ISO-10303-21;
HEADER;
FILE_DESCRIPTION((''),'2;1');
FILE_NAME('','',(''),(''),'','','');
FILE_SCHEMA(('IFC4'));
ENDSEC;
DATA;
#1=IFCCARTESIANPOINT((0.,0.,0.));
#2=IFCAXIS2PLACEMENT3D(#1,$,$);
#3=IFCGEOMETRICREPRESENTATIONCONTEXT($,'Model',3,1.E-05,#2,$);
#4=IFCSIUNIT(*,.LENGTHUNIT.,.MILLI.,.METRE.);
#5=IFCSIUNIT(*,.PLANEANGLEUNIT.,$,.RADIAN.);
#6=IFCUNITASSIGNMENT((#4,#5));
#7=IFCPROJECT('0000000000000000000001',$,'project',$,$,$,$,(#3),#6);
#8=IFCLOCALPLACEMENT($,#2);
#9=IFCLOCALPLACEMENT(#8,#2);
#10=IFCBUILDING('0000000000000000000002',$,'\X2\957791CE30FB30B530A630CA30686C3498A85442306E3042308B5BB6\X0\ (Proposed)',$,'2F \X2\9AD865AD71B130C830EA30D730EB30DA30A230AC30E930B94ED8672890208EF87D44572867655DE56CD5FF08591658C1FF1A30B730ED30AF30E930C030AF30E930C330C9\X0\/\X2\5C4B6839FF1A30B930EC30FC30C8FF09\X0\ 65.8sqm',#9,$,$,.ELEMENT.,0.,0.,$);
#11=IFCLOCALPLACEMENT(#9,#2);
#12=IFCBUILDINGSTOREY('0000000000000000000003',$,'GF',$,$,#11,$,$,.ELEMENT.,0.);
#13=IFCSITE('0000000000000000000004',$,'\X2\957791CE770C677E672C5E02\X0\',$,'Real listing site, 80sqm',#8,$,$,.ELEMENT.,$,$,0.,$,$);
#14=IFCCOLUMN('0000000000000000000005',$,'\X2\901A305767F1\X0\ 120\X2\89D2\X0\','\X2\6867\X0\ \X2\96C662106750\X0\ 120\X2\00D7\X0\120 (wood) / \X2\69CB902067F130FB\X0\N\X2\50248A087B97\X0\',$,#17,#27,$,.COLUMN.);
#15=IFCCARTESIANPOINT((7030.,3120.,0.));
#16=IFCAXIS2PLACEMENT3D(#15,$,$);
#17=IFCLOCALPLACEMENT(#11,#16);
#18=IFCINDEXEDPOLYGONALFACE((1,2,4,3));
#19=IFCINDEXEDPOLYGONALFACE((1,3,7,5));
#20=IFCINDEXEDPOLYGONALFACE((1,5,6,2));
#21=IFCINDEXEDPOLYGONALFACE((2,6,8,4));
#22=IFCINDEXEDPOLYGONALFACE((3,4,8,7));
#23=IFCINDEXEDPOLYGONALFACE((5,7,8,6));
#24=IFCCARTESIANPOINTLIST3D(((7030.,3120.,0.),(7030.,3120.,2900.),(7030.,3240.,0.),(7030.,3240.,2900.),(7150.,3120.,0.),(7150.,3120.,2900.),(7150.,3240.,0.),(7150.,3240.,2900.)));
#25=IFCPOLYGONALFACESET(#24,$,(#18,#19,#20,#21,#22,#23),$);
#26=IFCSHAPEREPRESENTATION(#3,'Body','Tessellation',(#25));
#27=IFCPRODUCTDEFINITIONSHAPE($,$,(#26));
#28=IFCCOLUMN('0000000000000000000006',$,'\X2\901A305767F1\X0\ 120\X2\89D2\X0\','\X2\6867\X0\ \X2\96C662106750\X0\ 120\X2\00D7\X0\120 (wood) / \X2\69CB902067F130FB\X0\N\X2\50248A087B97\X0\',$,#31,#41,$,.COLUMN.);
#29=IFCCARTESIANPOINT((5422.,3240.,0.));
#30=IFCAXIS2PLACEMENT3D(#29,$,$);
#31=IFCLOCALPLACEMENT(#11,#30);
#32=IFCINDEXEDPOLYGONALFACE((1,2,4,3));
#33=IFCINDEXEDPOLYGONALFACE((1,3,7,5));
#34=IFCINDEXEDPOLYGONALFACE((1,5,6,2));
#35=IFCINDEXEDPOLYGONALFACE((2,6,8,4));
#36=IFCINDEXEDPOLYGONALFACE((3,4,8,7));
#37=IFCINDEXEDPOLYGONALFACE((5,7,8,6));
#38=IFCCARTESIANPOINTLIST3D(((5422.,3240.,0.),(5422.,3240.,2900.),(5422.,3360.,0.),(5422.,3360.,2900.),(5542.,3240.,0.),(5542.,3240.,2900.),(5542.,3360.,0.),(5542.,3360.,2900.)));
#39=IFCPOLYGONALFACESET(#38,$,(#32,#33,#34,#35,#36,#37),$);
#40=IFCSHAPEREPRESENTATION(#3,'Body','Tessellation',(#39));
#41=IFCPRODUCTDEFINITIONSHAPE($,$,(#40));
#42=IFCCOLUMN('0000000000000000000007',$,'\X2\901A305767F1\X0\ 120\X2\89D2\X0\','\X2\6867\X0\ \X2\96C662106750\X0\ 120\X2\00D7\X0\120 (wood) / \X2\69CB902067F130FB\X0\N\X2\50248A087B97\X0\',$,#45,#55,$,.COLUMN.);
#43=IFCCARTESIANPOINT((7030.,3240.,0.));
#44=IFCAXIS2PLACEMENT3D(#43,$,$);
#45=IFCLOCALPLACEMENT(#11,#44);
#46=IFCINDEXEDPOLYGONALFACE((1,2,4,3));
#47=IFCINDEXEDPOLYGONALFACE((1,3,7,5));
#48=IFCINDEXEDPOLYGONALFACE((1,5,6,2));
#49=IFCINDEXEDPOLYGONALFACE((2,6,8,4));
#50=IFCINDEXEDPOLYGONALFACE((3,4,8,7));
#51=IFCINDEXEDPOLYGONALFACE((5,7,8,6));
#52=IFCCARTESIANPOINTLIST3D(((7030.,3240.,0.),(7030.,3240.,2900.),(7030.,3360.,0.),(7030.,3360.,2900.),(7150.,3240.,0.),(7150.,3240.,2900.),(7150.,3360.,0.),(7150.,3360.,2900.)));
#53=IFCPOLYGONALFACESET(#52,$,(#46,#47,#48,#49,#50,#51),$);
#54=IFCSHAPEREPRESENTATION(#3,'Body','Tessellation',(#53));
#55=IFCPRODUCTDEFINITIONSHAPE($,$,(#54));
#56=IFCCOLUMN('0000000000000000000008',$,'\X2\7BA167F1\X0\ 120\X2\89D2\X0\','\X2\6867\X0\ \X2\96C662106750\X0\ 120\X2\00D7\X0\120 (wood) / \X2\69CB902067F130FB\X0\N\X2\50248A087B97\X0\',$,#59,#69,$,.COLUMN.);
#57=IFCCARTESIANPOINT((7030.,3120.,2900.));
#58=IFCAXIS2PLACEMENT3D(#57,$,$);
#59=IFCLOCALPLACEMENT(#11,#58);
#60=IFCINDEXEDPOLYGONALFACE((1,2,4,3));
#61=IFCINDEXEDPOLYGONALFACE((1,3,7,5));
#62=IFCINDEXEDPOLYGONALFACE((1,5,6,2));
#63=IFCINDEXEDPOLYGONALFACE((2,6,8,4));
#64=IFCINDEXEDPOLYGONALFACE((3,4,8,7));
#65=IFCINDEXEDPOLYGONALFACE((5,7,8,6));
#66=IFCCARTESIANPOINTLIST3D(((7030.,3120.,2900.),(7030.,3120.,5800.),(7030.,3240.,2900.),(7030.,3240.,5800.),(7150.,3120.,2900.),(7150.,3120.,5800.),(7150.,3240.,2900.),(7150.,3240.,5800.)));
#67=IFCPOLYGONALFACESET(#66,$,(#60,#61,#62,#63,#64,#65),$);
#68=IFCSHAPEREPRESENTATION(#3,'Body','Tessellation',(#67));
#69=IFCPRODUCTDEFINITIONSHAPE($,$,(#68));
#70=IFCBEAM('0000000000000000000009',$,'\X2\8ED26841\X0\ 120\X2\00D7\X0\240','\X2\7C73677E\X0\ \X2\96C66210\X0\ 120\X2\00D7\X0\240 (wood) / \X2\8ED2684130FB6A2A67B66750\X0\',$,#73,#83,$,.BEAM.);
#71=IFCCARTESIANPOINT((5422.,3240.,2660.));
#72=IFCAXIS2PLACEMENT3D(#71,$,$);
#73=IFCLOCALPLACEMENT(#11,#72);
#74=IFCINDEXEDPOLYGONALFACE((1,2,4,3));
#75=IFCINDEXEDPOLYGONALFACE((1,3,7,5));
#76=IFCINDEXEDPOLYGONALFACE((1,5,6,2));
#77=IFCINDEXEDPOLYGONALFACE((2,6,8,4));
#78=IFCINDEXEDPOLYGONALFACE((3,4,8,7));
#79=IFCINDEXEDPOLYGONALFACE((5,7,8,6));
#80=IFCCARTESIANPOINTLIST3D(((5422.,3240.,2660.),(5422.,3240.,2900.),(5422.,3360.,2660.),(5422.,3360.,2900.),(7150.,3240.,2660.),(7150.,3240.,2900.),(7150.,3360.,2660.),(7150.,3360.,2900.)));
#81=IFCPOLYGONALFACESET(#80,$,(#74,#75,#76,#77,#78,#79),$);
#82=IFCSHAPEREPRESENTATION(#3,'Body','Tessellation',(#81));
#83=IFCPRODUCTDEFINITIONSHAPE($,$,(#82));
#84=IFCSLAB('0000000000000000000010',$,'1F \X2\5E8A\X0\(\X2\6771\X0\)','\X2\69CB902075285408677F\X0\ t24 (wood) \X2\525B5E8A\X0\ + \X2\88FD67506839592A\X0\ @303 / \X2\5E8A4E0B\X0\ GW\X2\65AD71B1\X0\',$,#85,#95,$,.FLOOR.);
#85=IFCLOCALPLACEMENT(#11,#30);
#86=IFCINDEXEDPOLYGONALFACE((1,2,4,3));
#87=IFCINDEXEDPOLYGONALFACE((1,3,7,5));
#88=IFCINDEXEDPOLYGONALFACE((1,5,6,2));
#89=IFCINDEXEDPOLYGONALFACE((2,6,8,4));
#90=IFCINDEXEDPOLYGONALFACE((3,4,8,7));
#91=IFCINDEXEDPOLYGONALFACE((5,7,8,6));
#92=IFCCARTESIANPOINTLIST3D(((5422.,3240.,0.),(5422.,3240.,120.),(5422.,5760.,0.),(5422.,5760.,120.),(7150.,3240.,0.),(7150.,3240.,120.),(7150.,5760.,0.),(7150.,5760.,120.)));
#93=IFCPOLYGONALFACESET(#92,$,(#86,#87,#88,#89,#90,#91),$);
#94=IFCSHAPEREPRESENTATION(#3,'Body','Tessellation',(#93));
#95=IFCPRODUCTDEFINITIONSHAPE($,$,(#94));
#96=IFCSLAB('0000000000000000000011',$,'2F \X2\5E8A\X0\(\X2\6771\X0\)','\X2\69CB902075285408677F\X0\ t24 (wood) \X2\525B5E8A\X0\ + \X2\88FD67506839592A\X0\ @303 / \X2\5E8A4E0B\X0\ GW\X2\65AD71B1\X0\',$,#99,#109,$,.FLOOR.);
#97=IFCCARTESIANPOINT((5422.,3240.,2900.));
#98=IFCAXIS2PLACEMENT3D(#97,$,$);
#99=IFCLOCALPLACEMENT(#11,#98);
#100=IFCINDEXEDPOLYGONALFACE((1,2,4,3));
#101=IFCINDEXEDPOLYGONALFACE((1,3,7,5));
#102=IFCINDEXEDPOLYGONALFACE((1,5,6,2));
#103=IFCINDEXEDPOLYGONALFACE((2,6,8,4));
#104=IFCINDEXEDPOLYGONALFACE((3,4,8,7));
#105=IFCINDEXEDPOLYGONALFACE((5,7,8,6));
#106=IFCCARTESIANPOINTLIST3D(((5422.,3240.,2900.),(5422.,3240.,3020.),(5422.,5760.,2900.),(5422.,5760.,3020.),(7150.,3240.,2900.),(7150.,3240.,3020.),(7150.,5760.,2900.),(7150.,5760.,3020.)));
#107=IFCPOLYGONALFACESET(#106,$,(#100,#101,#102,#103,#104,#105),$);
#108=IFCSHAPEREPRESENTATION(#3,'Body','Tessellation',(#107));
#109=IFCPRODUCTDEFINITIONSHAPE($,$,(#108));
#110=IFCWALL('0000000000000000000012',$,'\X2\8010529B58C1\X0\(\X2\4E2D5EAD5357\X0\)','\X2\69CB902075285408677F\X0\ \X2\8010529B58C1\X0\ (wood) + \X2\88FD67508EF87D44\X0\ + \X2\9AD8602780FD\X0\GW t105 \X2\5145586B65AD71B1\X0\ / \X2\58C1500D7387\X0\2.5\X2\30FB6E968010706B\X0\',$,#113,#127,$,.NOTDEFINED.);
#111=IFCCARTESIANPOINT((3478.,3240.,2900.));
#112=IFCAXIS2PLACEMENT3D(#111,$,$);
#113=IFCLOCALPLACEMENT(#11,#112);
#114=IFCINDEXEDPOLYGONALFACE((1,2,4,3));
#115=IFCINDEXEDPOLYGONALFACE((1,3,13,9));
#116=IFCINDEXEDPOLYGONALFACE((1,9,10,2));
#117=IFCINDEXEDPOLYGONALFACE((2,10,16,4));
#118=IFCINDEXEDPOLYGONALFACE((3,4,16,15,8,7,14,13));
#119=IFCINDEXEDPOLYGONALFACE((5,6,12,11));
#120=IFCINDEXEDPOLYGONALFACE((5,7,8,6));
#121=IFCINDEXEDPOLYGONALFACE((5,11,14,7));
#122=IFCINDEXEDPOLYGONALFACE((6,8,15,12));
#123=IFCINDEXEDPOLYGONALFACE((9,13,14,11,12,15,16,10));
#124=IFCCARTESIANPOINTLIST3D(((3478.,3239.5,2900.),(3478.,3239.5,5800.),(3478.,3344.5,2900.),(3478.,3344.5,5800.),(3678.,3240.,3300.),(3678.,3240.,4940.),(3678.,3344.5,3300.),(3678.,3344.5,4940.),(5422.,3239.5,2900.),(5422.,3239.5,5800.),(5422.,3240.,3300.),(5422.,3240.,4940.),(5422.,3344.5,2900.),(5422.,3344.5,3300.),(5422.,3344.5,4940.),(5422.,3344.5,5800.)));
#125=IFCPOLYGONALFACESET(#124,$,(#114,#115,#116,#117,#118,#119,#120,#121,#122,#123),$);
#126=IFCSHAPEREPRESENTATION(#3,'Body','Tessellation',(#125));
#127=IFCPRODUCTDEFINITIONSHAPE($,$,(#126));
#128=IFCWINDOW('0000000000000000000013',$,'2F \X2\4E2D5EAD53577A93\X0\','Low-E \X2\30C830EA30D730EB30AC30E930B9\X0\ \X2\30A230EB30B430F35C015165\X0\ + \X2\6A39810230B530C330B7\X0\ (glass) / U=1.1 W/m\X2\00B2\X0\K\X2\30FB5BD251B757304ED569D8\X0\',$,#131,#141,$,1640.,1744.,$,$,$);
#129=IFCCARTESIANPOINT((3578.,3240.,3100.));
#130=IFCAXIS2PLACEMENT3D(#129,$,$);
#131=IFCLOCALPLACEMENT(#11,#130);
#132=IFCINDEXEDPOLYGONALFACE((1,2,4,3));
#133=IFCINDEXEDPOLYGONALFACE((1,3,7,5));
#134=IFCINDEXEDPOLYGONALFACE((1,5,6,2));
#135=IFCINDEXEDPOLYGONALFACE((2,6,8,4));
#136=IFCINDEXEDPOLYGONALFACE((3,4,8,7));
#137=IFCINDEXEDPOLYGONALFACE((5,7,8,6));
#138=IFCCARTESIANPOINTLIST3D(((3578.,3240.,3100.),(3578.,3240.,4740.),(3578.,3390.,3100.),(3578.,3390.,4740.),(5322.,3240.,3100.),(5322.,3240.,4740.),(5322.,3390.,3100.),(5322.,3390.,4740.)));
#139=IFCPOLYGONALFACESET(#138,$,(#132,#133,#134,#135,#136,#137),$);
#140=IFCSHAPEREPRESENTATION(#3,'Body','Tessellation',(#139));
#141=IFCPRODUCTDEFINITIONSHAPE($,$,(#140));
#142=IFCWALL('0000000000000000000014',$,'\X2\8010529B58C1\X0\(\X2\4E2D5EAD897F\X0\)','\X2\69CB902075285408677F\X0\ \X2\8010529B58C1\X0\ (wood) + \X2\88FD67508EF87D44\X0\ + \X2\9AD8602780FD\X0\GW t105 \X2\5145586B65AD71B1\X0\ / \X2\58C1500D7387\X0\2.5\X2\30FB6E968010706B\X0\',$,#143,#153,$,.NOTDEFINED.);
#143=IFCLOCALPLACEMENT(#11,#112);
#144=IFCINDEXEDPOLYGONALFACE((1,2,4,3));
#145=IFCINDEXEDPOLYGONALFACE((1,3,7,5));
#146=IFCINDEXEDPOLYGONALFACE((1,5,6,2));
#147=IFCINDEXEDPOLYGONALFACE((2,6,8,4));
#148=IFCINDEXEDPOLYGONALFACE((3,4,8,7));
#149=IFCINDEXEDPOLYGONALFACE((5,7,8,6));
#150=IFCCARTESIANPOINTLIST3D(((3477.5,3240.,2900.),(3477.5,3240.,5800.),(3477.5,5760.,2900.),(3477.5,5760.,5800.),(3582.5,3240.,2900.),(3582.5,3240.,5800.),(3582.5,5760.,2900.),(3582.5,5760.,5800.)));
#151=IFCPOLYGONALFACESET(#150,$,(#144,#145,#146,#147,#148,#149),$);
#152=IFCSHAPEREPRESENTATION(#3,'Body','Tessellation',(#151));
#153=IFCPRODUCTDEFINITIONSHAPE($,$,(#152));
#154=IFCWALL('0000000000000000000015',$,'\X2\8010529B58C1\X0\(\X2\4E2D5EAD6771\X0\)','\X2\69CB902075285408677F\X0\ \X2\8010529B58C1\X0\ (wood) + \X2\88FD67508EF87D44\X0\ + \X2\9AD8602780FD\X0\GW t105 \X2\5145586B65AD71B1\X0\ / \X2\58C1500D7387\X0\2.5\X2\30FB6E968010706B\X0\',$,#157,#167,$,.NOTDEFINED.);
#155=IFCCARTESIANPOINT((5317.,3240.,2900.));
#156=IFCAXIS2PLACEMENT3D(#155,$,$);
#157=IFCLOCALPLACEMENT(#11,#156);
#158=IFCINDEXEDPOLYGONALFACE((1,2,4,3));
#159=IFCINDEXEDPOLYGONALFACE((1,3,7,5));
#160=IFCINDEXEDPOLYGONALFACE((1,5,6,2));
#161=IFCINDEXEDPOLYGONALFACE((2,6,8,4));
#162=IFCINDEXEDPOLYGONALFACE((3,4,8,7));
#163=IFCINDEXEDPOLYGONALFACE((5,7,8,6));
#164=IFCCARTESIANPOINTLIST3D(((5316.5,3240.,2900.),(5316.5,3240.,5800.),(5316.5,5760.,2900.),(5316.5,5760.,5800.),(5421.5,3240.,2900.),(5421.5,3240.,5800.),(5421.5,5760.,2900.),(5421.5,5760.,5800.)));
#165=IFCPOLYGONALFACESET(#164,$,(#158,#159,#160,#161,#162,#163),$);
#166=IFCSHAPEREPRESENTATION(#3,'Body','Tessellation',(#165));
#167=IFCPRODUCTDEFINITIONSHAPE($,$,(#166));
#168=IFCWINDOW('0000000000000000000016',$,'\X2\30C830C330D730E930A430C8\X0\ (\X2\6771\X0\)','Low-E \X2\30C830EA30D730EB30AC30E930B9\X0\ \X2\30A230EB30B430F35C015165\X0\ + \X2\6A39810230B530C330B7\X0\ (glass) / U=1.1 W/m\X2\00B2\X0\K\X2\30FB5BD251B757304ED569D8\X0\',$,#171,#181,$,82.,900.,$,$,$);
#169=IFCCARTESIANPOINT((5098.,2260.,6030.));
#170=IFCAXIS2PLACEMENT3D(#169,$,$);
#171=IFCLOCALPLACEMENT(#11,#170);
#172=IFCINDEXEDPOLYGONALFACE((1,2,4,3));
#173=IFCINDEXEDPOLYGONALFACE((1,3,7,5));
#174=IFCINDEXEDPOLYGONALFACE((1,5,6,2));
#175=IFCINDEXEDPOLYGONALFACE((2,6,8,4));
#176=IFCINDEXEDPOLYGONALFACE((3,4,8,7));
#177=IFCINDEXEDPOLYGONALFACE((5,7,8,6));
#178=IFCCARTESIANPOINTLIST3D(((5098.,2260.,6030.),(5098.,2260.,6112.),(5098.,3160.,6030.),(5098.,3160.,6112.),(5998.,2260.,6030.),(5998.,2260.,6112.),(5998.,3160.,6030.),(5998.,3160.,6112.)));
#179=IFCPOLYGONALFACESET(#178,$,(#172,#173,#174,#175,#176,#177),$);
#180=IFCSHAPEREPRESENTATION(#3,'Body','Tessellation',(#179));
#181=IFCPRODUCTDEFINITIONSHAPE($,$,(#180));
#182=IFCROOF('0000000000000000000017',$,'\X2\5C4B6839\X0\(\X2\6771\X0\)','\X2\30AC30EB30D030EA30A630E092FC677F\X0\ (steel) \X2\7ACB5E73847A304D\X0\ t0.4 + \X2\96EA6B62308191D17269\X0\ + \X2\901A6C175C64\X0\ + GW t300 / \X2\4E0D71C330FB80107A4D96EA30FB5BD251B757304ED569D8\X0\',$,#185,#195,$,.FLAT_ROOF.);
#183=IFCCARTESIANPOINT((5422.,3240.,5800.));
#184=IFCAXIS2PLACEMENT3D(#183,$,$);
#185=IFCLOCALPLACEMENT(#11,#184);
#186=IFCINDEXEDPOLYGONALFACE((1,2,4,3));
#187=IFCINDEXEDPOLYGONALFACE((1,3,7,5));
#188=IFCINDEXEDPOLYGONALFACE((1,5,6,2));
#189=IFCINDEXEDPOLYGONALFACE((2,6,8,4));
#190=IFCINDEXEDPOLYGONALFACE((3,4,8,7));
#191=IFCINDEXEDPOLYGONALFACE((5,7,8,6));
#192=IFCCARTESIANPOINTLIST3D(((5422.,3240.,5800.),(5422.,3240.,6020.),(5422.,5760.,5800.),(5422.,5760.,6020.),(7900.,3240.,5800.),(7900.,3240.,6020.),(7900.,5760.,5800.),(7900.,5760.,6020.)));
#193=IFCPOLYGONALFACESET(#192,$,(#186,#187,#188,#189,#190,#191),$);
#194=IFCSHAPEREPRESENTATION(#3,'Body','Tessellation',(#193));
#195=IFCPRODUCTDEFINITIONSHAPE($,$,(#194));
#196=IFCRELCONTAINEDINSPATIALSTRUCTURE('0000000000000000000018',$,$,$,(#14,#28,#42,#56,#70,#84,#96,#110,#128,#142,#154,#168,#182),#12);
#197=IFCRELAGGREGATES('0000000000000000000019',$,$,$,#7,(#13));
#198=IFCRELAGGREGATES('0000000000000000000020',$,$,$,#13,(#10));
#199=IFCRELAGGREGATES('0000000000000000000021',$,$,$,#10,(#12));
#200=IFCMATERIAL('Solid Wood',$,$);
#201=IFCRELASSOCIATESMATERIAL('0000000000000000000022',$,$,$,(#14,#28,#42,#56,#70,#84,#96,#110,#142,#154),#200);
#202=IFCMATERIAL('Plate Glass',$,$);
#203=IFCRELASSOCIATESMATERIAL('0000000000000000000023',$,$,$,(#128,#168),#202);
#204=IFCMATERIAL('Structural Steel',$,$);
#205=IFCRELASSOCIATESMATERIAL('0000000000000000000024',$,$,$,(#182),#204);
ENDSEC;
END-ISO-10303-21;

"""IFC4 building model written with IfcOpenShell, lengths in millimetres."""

from ifc_helpers import new_model, si_unit, frame, frame_2d, origin, place, context, project, spatial, rectangle, extrude, material, element, fill, save


model = new_model("IFC4")

# Units and contexts
model_context = context("Model", 3, precision=1e-05, world=origin())
ifc_project = project(units=[si_unit("LENGTHUNIT", "METRE", prefix="MILLI"), si_unit("PLANEANGLEUNIT", "RADIAN")], contexts=[model_context])

# Site, building, storey
site_placement = place(None, origin())
site = spatial("IfcSite", under=ifc_project, at=site_placement, Name="長野県松本市", ObjectType="Real listing site, 80sqm", CompositionType="ELEMENT", RefElevation=0.0)
building_placement = place(site_placement, origin())
building = spatial("IfcBuilding", under=site, at=building_placement, Name="長野・サウナと水風呂のある家 (Proposed)", ObjectType="2F 高断熱トリプルペアガラス付木造軸組在来工法（外壁：シロクラダクラッド/屋根：スレート） 65.8sqm", CompositionType="ELEMENT", ElevationOfRefHeight=0.0, ElevationOfTerrain=0.0)
storey_placement = place(building_placement, origin())
storey = spatial("IfcBuildingStorey", under=building, at=storey_placement, Name="GF", CompositionType="ELEMENT", Elevation=0.0)

# Columns
ifc_material_1 = material(Name="Solid Wood")
column_1_placement = place(storey_placement, frame((7030.0, 3120.0, 0.0)))
element("IfcColumn", 1, at=column_1_placement, inside=storey, material=ifc_material_1, Name="通し柱 120角", Description="桧 集成材 120×120 (wood) / 構造柱・N値計算", PredefinedType="COLUMN", context=model_context, shape_type="SweptSolid", body=[
    extrude(rectangle(XDim=120.0, YDim=120.0, at=frame_2d((60.0, 60.0))), frame((7030.0, 3120.0, 0.0)), (0.0, 0.0, 1.0), 2900.0),
])
column_2_placement = place(storey_placement, frame((5422.0, 3240.0, 0.0)))
element("IfcColumn", 2, at=column_2_placement, inside=storey, material=ifc_material_1, Name="通し柱 120角", Description="桧 集成材 120×120 (wood) / 構造柱・N値計算", PredefinedType="COLUMN", context=model_context, shape_type="SweptSolid", body=[
    extrude(rectangle(XDim=120.0, YDim=120.0, at=frame_2d((60.0, 60.0))), frame((5422.0, 3240.0, 0.0)), (0.0, 0.0, 1.0), 2900.0),
])
column_3_placement = place(storey_placement, frame((7030.0, 3240.0, 0.0)))
element("IfcColumn", 3, at=column_3_placement, inside=storey, material=ifc_material_1, Name="通し柱 120角", Description="桧 集成材 120×120 (wood) / 構造柱・N値計算", PredefinedType="COLUMN", context=model_context, shape_type="SweptSolid", body=[
    extrude(rectangle(XDim=120.0, YDim=120.0, at=frame_2d((60.0, 60.0))), frame((7030.0, 3240.0, 0.0)), (0.0, 0.0, 1.0), 2900.0),
])
column_4_placement = place(storey_placement, frame((7030.0, 3120.0, 2900.0)))
element("IfcColumn", 4, at=column_4_placement, inside=storey, material=ifc_material_1, Name="管柱 120角", Description="桧 集成材 120×120 (wood) / 構造柱・N値計算", PredefinedType="COLUMN", context=model_context, shape_type="SweptSolid", body=[
    extrude(rectangle(XDim=120.0, YDim=120.0, at=frame_2d((60.0, 60.0))), frame((7030.0, 3120.0, 2900.0)), (0.0, 0.0, 1.0), 2900.0),
])

# Beam
beam_1_placement = place(storey_placement, frame((5422.0, 3240.0, 2660.0)))
element("IfcBeam", 5, at=beam_1_placement, inside=storey, material=ifc_material_1, Name="軒桁 120×240", Description="米松 集成 120×240 (wood) / 軒桁・横架材", PredefinedType="BEAM", context=model_context, shape_type="SweptSolid", body=[
    extrude(rectangle(XDim=1728.0, YDim=120.0, at=frame_2d((864.0, 60.0))), frame((5422.0, 3240.0, 2660.0)), (0.0, 0.0, 1.0), 240.0),
])

# Slabs
slab_1_placement = place(storey_placement, frame((5422.0, 3240.0, 0.0)))
element("IfcSlab", 6, at=slab_1_placement, inside=storey, material=ifc_material_1, Name="1F 床(東)", Description="構造用合板 t24 (wood) 剛床 + 製材根太 @303 / 床下 GW断熱", PredefinedType="FLOOR", context=model_context, shape_type="SweptSolid", body=[
    extrude(rectangle(XDim=1728.0, YDim=2520.0, at=frame_2d((864.0, 1260.0))), frame((5422.0, 3240.0, 0.0)), (0.0, 0.0, 1.0), 120.0),
])
slab_2_placement = place(storey_placement, frame((5422.0, 3240.0, 2900.0)))
element("IfcSlab", 7, at=slab_2_placement, inside=storey, material=ifc_material_1, Name="2F 床(東)", Description="構造用合板 t24 (wood) 剛床 + 製材根太 @303 / 床下 GW断熱", PredefinedType="FLOOR", context=model_context, shape_type="SweptSolid", body=[
    extrude(rectangle(XDim=1728.0, YDim=2520.0, at=frame_2d((864.0, 1260.0))), frame((5422.0, 3240.0, 2900.0)), (0.0, 0.0, 1.0), 120.0),
])

# Wall, opening, window
wall_1_placement = place(storey_placement, frame((3478.0, 3240.0, 2900.0)))
wall_1 = element("IfcWall", 8, at=wall_1_placement, inside=storey, material=ifc_material_1, Name="耐力壁(中庭南)", Description="構造用合板 耐力壁 (wood) + 製材軸組 + 高性能GW t105 充填断熱 / 壁倍率2.5・準耐火", PredefinedType="NOTDEFINED", context=model_context, shape_type="SweptSolid", body=[
    extrude(rectangle(XDim=1944.0, YDim=105.0, at=frame_2d((972.0, 52.0))), frame((3478.0, 3240.0, 2900.0)), (0.0, 0.0, 1.0), 2900.0),
])
opening_placement = place(storey_placement, frame((3578.0, 3240.0, 3100.0)))
opening = element("IfcOpeningElement", 9, at=opening_placement, cuts=wall_1, PredefinedType="NOTDEFINED", context=model_context, shape_type="SweptSolid", body=[
    extrude(rectangle(XDim=1744.0, YDim=150.0, at=frame_2d((872.0, 75.0))), frame((3578.0, 3240.0, 3100.0)), (0.0, 0.0, 1.0), 1640.0),
])
ifc_material_2 = material(Name="Plate Glass")
window_1_placement = place(storey_placement, frame((3578.0, 3240.0, 3100.0)))
window_1 = element("IfcWindow", 10, at=window_1_placement, inside=storey, material=ifc_material_2, Name="2F 中庭南窓", Description="Low-E トリプルガラス アルゴン封入 + 樹脂サッシ (glass) / U=1.1 W/m²K・寒冷地仕様", OverallHeight=1640.0, OverallWidth=1744.0, context=model_context, shape_type="SweptSolid", body=[
    extrude(rectangle(XDim=1744.0, YDim=150.0, at=frame_2d((872.0, 75.0))), frame((3578.0, 3240.0, 3100.0)), (0.0, 0.0, 1.0), 1640.0),
])
fill(opening, window_1)

# Walls
wall_2_placement = place(storey_placement, frame((3478.0, 3240.0, 2900.0)))
element("IfcWall", 11, at=wall_2_placement, inside=storey, material=ifc_material_1, Name="耐力壁(中庭西)", Description="構造用合板 耐力壁 (wood) + 製材軸組 + 高性能GW t105 充填断熱 / 壁倍率2.5・準耐火", PredefinedType="NOTDEFINED", context=model_context, shape_type="SweptSolid", body=[
    extrude(rectangle(XDim=105.0, YDim=2520.0, at=frame_2d((52.0, 1260.0))), frame((3478.0, 3240.0, 2900.0)), (0.0, 0.0, 1.0), 2900.0),
])
wall_3_placement = place(storey_placement, frame((5317.0, 3240.0, 2900.0)))
element("IfcWall", 12, at=wall_3_placement, inside=storey, material=ifc_material_1, Name="耐力壁(中庭東)", Description="構造用合板 耐力壁 (wood) + 製材軸組 + 高性能GW t105 充填断熱 / 壁倍率2.5・準耐火", PredefinedType="NOTDEFINED", context=model_context, shape_type="SweptSolid", body=[
    extrude(rectangle(XDim=105.0, YDim=2520.0, at=frame_2d((52.0, 1260.0))), frame((5317.0, 3240.0, 2900.0)), (0.0, 0.0, 1.0), 2900.0),
])

# Window
window_2_placement = place(storey_placement, frame((5098.0, 2260.0, 6030.0)))
element("IfcWindow", 13, at=window_2_placement, inside=storey, material=ifc_material_2, Name="トップライト (東)", Description="Low-E トリプルガラス アルゴン封入 + 樹脂サッシ (glass) / U=1.1 W/m²K・寒冷地仕様", OverallHeight=82.0, OverallWidth=900.0, context=model_context, shape_type="SweptSolid", body=[
    extrude(rectangle(XDim=900.0, YDim=900.0, at=frame_2d((450.0, 450.0))), frame((5098.0, 2260.0, 6030.0)), (0.0, 0.0, 1.0), 82.0),
])

# Roof
ifc_material_3 = material(Name="Structural Steel")
for number, where, name in (
    (14, (5422.0, 3240.0, 5800.0), "屋根(東)"),
):
    element("IfcRoof", number, at=place(storey_placement, frame(where)), inside=storey, material=ifc_material_3, Name=name, Description="ガルバリウム鋼板 (steel) 立平葺き t0.4 + 雪止め金物 + 通気層 + GW t300 / 不燃・耐積雪・寒冷地仕様", PredefinedType="FLAT_ROOF", context=model_context, shape_type="SweptSolid", body=[
        extrude(rectangle(XDim=2478.0, YDim=2520.0, at=frame_2d((1239.0, 1260.0))), frame((5422.0, 3240.0, 5800.0)), (0.0, 0.0, 1.0), 220.0),
    ])

save(model, "model.ifc")
